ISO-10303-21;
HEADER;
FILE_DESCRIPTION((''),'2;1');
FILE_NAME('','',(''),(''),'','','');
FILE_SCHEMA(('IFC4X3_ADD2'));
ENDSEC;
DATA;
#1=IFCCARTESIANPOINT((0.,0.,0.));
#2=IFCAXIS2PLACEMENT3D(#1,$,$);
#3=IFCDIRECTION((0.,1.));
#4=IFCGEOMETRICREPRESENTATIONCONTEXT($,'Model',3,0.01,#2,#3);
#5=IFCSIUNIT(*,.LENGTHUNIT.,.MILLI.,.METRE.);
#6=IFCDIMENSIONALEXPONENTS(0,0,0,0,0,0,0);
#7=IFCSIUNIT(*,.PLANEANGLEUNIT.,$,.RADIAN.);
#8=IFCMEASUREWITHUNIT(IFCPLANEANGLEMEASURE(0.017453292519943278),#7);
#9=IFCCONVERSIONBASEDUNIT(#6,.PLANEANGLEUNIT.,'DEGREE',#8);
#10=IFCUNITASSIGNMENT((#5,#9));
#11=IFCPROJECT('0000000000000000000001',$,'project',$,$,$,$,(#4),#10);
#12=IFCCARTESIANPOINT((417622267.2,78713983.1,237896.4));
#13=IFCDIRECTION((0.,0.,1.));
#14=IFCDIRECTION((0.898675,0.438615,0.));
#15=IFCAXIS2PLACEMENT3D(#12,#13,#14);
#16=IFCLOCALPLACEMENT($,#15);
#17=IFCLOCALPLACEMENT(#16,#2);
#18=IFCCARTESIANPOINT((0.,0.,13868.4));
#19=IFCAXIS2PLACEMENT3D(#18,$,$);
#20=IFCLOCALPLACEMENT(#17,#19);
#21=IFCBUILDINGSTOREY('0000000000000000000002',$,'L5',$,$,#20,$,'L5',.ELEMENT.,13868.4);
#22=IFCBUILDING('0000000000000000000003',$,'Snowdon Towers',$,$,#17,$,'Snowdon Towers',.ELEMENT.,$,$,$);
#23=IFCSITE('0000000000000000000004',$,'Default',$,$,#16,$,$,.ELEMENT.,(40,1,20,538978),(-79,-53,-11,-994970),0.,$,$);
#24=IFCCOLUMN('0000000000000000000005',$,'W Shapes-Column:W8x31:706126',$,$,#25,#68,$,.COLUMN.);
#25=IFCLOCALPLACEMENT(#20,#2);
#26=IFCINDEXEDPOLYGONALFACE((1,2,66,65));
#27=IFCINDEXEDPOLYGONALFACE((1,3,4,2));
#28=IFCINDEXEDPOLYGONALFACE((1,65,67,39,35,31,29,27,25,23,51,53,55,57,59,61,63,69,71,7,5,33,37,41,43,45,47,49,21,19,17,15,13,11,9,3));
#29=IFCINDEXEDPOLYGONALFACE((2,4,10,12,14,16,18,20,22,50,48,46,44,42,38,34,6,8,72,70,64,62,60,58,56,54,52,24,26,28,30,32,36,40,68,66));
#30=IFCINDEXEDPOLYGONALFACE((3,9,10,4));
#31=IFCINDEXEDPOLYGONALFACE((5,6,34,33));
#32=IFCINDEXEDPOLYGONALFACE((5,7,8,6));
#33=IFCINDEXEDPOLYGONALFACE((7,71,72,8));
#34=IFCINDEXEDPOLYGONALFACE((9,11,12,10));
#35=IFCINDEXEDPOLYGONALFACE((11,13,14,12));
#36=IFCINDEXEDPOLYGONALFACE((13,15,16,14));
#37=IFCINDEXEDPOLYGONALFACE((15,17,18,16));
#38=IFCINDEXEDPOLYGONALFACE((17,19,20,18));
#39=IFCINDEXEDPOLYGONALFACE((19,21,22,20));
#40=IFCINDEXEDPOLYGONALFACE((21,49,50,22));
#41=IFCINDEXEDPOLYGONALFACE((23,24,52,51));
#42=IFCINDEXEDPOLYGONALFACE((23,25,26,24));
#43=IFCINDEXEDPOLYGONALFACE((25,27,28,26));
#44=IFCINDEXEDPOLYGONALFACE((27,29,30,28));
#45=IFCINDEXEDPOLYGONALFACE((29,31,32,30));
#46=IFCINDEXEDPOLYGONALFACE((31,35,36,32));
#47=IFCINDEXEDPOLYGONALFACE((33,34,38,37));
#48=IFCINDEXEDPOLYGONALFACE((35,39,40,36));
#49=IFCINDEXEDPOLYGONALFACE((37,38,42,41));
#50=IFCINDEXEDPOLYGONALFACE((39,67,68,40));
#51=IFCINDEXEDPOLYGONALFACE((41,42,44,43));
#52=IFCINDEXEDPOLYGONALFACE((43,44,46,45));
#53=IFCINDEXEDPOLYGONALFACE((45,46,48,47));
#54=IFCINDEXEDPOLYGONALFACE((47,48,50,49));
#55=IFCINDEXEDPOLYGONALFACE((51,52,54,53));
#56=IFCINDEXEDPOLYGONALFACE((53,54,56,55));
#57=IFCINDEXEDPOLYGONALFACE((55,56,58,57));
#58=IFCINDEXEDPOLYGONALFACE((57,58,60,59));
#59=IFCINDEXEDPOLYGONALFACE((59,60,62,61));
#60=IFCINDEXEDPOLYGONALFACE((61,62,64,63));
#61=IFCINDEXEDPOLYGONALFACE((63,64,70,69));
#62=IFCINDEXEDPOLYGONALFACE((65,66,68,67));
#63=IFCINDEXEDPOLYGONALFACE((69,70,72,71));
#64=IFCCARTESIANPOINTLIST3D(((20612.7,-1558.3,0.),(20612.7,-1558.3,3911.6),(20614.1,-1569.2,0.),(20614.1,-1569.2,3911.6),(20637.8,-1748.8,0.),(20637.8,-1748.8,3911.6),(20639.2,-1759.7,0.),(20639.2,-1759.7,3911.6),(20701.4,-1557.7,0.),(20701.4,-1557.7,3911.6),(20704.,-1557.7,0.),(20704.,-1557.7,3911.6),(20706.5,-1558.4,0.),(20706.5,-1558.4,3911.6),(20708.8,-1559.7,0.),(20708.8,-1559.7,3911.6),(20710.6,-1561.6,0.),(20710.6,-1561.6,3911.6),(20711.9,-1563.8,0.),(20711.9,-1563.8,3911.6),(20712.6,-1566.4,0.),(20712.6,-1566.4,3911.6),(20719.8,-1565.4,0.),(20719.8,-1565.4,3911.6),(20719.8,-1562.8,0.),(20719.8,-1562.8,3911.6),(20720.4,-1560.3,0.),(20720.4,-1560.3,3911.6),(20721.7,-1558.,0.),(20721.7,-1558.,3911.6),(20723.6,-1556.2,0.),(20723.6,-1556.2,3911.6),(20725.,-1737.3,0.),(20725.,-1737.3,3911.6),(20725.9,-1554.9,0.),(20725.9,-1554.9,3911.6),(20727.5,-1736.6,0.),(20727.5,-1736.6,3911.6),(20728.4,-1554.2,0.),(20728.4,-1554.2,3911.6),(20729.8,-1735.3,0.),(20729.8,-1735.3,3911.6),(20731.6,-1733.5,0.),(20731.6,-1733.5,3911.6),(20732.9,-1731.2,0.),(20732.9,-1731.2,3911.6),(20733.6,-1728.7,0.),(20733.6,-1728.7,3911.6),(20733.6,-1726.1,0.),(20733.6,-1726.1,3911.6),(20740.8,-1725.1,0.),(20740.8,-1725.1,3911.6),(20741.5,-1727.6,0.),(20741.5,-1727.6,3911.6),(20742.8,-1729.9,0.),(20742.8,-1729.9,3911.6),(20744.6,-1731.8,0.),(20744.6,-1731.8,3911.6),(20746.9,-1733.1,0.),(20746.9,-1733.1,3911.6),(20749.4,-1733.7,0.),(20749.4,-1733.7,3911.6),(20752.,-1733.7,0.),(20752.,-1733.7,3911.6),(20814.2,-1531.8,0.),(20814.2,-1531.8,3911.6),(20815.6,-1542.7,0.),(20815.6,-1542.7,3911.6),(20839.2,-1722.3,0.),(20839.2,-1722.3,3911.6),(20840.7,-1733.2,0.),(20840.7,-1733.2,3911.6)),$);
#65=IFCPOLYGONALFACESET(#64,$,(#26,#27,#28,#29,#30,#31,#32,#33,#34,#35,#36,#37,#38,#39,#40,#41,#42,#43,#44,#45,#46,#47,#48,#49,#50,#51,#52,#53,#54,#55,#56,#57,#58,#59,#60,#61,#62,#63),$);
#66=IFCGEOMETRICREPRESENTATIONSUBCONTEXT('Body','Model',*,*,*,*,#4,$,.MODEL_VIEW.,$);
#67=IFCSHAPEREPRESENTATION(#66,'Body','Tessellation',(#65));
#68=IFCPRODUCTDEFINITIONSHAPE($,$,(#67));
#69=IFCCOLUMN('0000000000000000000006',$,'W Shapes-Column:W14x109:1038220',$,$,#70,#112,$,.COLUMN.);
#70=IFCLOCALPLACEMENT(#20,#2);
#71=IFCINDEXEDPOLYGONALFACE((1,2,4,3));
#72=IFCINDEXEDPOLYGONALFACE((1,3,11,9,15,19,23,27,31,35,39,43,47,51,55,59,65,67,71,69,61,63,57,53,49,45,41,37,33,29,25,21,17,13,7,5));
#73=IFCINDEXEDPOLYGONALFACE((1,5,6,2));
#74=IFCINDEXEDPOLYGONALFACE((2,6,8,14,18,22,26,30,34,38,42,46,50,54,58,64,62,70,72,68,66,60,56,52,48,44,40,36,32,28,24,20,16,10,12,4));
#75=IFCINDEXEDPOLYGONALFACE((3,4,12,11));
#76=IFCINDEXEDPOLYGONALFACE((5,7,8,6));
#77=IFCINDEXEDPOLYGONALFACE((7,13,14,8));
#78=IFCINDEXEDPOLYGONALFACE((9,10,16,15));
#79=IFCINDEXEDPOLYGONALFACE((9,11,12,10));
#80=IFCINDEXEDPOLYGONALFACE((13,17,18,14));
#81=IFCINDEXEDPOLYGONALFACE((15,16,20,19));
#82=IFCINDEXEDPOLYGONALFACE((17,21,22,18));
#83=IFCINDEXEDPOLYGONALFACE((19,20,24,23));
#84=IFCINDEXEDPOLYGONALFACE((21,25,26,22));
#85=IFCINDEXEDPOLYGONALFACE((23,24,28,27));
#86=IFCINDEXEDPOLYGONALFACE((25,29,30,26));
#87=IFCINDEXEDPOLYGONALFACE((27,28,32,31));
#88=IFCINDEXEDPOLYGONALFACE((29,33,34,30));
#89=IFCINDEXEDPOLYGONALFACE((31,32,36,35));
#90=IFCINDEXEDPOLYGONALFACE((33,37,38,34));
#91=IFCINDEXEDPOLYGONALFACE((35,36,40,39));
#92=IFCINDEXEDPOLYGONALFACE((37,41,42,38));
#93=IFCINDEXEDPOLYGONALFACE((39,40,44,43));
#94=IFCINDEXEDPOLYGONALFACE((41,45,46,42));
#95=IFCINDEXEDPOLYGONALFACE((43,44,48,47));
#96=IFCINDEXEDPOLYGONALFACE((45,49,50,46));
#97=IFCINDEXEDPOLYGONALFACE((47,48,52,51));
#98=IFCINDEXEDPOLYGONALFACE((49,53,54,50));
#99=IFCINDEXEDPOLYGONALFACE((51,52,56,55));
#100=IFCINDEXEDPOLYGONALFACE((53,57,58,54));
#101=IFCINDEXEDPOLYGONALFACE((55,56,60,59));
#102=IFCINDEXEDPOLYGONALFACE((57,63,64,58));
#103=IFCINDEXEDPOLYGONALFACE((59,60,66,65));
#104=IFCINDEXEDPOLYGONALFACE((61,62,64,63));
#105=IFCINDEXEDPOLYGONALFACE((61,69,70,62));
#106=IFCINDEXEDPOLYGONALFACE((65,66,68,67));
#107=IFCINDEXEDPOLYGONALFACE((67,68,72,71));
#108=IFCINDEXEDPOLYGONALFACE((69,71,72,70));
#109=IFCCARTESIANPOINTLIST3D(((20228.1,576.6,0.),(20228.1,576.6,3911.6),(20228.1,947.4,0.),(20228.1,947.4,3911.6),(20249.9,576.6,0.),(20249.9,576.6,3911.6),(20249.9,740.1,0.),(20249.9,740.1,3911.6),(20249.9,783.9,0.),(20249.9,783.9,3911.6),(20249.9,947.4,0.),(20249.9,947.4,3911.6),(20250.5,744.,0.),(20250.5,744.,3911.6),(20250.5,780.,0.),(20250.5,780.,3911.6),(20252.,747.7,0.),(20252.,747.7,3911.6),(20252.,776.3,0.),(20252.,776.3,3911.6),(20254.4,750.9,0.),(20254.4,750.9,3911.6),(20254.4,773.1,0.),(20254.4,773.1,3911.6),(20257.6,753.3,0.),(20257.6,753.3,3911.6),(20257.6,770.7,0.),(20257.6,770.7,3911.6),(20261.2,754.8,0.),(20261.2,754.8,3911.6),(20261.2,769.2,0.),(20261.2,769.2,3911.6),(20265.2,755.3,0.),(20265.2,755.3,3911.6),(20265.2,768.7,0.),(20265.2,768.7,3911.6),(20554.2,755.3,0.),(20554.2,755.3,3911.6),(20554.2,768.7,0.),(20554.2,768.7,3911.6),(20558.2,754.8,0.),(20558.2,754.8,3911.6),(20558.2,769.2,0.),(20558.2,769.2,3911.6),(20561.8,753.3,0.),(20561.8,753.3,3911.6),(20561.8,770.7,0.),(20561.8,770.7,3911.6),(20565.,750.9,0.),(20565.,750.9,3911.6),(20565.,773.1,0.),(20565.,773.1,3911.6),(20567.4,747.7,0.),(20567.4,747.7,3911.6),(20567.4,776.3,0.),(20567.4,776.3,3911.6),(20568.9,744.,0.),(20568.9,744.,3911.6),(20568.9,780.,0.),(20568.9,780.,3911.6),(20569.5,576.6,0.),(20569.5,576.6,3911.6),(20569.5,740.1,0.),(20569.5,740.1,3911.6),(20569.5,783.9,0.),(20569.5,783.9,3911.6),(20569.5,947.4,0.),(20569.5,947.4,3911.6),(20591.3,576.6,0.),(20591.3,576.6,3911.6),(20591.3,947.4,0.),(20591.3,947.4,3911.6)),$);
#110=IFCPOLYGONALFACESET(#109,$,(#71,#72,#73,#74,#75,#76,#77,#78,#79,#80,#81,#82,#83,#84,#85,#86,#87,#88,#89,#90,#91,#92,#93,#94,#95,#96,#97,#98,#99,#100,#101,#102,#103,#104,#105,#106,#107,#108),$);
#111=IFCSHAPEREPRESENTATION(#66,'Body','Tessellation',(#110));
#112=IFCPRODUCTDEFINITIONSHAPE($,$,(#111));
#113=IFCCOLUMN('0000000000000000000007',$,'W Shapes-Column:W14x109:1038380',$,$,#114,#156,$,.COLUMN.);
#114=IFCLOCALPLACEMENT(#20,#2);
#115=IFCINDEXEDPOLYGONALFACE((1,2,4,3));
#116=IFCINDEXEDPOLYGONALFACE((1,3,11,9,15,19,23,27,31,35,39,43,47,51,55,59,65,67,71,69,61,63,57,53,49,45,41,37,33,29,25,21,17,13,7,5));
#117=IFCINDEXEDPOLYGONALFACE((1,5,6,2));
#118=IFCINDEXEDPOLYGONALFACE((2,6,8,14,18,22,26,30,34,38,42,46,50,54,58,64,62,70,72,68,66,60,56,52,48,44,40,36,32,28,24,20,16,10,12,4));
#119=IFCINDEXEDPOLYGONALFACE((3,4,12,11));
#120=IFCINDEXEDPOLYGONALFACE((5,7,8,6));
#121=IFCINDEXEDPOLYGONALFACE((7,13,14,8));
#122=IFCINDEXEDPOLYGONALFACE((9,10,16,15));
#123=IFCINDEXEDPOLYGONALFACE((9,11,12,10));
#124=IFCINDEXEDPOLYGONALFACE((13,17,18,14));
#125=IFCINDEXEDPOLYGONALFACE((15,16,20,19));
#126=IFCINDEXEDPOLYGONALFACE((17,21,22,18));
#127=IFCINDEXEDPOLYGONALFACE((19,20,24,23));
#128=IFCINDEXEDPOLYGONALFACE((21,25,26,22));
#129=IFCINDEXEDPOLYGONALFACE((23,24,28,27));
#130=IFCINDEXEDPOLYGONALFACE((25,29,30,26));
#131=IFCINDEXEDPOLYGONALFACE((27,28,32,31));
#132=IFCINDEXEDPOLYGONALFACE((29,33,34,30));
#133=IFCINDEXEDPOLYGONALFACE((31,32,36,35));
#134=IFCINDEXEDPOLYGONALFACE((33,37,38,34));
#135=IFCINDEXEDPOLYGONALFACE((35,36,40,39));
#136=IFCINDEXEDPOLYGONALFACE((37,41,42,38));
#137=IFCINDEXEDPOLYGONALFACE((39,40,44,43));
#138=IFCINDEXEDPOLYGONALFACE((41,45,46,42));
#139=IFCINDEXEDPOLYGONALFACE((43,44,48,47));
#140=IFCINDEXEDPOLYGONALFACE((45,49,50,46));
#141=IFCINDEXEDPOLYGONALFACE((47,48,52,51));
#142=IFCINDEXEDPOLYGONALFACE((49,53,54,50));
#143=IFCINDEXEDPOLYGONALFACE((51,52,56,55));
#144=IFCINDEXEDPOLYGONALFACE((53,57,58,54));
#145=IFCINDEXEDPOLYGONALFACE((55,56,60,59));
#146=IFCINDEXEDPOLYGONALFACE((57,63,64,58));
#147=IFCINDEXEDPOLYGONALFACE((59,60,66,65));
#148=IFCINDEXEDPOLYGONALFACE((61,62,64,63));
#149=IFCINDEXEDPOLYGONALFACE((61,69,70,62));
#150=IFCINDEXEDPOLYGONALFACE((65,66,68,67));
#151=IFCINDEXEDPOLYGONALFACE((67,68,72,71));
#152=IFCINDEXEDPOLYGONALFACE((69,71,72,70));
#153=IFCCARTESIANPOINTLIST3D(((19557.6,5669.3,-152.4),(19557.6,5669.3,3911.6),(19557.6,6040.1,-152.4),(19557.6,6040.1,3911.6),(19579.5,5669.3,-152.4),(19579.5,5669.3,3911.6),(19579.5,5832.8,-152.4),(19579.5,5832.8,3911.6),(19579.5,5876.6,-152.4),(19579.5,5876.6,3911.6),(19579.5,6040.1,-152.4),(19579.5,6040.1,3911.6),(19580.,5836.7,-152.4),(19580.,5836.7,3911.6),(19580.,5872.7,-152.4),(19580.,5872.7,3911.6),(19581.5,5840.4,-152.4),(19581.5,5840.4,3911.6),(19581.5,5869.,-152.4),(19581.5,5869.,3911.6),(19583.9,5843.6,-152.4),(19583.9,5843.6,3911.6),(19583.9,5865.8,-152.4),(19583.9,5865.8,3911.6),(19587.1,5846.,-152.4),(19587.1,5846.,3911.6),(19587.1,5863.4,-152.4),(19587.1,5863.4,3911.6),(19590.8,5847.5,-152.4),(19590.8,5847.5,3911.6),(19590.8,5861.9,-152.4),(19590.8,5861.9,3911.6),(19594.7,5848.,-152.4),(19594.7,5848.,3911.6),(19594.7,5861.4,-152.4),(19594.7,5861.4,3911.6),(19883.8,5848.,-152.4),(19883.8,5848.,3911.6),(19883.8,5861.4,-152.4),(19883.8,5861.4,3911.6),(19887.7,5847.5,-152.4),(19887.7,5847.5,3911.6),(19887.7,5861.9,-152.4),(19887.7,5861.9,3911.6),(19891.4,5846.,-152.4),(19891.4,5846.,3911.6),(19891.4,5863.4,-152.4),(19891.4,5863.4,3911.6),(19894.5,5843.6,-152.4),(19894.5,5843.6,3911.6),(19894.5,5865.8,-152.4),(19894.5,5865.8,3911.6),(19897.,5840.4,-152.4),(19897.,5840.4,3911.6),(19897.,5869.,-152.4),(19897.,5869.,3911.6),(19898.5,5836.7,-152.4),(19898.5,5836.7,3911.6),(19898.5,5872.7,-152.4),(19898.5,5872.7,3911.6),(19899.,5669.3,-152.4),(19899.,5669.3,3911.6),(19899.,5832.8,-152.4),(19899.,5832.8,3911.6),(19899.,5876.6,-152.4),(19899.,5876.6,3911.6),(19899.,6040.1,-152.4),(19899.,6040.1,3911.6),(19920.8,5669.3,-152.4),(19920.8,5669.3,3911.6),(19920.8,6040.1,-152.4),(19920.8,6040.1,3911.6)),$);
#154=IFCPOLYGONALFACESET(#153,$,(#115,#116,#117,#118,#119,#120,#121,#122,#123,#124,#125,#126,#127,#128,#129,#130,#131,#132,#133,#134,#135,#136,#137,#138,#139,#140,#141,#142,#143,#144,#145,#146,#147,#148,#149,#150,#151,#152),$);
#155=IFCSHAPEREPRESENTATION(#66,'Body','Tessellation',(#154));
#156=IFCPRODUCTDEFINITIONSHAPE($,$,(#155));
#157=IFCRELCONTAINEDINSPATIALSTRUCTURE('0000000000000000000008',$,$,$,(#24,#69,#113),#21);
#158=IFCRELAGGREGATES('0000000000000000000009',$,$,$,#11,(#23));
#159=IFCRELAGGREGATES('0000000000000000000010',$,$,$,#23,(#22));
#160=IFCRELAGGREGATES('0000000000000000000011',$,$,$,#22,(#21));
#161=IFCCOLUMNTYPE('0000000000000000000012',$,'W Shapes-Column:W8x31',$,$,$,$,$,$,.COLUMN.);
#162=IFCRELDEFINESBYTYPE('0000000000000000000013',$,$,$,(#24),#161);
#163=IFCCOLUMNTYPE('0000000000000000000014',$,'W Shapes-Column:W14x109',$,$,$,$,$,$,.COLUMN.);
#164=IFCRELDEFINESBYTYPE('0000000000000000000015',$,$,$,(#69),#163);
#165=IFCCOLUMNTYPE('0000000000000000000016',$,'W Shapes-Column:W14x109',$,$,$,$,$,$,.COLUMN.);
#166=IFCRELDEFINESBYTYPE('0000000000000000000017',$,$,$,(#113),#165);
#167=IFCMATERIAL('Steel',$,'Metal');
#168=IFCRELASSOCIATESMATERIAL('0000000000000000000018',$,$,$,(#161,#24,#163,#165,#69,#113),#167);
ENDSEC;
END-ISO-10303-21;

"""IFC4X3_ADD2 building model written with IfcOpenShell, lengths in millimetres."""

from ifc_helpers import new_model, entity, si_unit, converted_unit, direction, frame, frame_2d, origin, place, context, subcontext, project, spatial, i_section, extrude, source, transform, mapped, material, material_profile, profile_set, profile_usage, type_object, type_shapes, element, save


model = new_model("IFC4X3_ADD2")

# Units and contexts
model_context = context("Model", 3, precision=0.01, world=origin(), true_north=direction((0.0, 1.0)))
body_context = subcontext(model_context, "Body", "Model", "MODEL_VIEW")
ifc_project = project(units=[si_unit("LENGTHUNIT", "METRE", prefix="MILLI"), converted_unit("PLANEANGLEUNIT", "DEGREE", entity("IfcPlaneAngleMeasure", 0.017453292519943278), si_unit("PLANEANGLEUNIT", "RADIAN"), dimensions=[0, 0, 0, 0, 0, 0, 0])], contexts=[model_context])

# Site, building, storey
site_placement = place(None, frame((417622267.2, 78713983.1, 237896.4), z_axis=(0.0, 0.0, 1.0), x_axis=(0.898675, 0.438615, 0.0)))
site = spatial("IfcSite", under=ifc_project, at=site_placement, Name="Default", CompositionType="ELEMENT", RefLatitude=(40, 1, 20, 538978), RefLongitude=(-79, -53, -11, -994970), RefElevation=0.0)
building_placement = place(site_placement, origin())
building = spatial("IfcBuilding", under=site, at=building_placement, Name="Snowdon Towers", LongName="Snowdon Towers", CompositionType="ELEMENT")
storey_placement = place(building_placement, frame((0.0, 0.0, 13868.4)))
storey = spatial("IfcBuildingStorey", under=building, at=storey_placement, Name="L5", LongName="L5", CompositionType="ELEMENT", Elevation=13868.4)

# Columns
ifc_material_1 = material(Name="Steel", Category="Metal")
ifc_material_profile_1 = material_profile(ifc_material_1, i_section(OverallWidth=203.2, OverallDepth=203.2, WebThickness=7.2, FlangeThickness=11.0, FilletRadius=10.0, at=frame_2d((0.0, 0.0), x_axis=(1.0, 0.0))), Name="W8x31")
ifc_profile_set_1 = profile_set([ifc_material_profile_1], Name="W8x31")
ifc_profile_usage_1 = profile_usage(ifc_profile_set_1)
column_type_1 = type_object("IfcColumnType", Name="W Shapes-Column:W8x31", PredefinedType="COLUMN", material=ifc_profile_set_1)
shared_shape_1 = source(origin(), body_context, "Body", "SweptSolid", [
    extrude(i_section(OverallWidth=203.2, OverallDepth=203.2, WebThickness=7.2, FlangeThickness=11.0, FilletRadius=10.0, at=frame_2d((0.0, 0.0), x_axis=(1.0, 0.0))), frame((0.0, 0.0, 13868.4), z_axis=(0.0, 0.0, 1.0), x_axis=(-1.0, 0.0, 0.0)), (0.0, 0.0, 1.0), 3911.6),
])
type_shapes(column_type_1, [shared_shape_1])
column_1_placement = place(storey_placement, frame((20726.7, -1645.7, -13868.4), z_axis=(0.0, 0.0, 1.0), x_axis=(0.991445, 0.130526, 0.0)))
element("IfcColumn", 1, at=column_1_placement, inside=storey, type_object=column_type_1, material=ifc_profile_usage_1, Name="W Shapes-Column:W8x31:706126", PredefinedType="COLUMN", context=body_context, shape_type="MappedRepresentation", body=[
    mapped(shared_shape_1, transform((0.0, 0.0, 0.0), scale=1.0)),
])
ifc_material_profile_2 = material_profile(ifc_material_1, i_section(OverallWidth=370.8, OverallDepth=363.2, WebThickness=13.3, FlangeThickness=21.8, FilletRadius=15.2, at=frame_2d((0.0, 0.0), x_axis=(1.0, 0.0))), Name="W14x109")
ifc_profile_set_2 = profile_set([ifc_material_profile_2], Name="W14x109")
ifc_profile_usage_2 = profile_usage(ifc_profile_set_2)
column_type_2 = type_object("IfcColumnType", Name="W Shapes-Column:W14x109", PredefinedType="COLUMN", material=ifc_profile_set_2)
shared_shape_2 = source(origin(), body_context, "Body", "SweptSolid", [
    extrude(i_section(OverallWidth=370.8, OverallDepth=363.2, WebThickness=13.3, FlangeThickness=21.8, FilletRadius=15.2, at=frame_2d((0.0, 0.0), x_axis=(1.0, 0.0))), frame((0.0, 0.0, 13868.4), z_axis=(0.0, 0.0, 1.0), x_axis=(-1.0, 0.0, 0.0)), (0.0, 0.0, 1.0), 3911.6),
])
type_shapes(column_type_2, [shared_shape_2])
column_2_placement = place(storey_placement, frame((20409.7, 762.0, -13868.4), z_axis=(0.0, 0.0, 1.0), x_axis=(0.0, 1.0, 0.0)))
element("IfcColumn", 2, at=column_2_placement, inside=storey, type_object=column_type_2, material=ifc_profile_usage_2, Name="W Shapes-Column:W14x109:1038220", PredefinedType="COLUMN", context=body_context, shape_type="MappedRepresentation", body=[
    mapped(shared_shape_2, transform((0.0, 0.0, 0.0), scale=1.0)),
])
column_type_3 = type_object("IfcColumnType", Name="W Shapes-Column:W14x109", PredefinedType="COLUMN", material=ifc_profile_set_2)
shared_shape_3 = source(origin(), body_context, "Body", "SweptSolid", [
    extrude(i_section(OverallWidth=370.8, OverallDepth=363.2, WebThickness=13.3, FlangeThickness=21.8, FilletRadius=15.2, at=frame_2d((0.0, 0.0), x_axis=(1.0, 0.0))), frame((0.0, 0.0, 13716.0), z_axis=(0.0, 0.0, 1.0), x_axis=(-1.0, 0.0, 0.0)), (0.0, 0.0, 1.0), 4064.0),
])
type_shapes(column_type_3, [shared_shape_3])
column_3_placement = place(storey_placement, frame((19739.2, 5854.7, -13868.4), z_axis=(0.0, 0.0, 1.0), x_axis=(0.0, 1.0, 0.0)))
element("IfcColumn", 3, at=column_3_placement, inside=storey, type_object=column_type_3, material=ifc_profile_usage_2, Name="W Shapes-Column:W14x109:1038380", PredefinedType="COLUMN", context=body_context, shape_type="MappedRepresentation", body=[
    mapped(shared_shape_3, transform((0.0, 0.0, 0.0), scale=1.0)),
])

save(model, "model.ifc")
